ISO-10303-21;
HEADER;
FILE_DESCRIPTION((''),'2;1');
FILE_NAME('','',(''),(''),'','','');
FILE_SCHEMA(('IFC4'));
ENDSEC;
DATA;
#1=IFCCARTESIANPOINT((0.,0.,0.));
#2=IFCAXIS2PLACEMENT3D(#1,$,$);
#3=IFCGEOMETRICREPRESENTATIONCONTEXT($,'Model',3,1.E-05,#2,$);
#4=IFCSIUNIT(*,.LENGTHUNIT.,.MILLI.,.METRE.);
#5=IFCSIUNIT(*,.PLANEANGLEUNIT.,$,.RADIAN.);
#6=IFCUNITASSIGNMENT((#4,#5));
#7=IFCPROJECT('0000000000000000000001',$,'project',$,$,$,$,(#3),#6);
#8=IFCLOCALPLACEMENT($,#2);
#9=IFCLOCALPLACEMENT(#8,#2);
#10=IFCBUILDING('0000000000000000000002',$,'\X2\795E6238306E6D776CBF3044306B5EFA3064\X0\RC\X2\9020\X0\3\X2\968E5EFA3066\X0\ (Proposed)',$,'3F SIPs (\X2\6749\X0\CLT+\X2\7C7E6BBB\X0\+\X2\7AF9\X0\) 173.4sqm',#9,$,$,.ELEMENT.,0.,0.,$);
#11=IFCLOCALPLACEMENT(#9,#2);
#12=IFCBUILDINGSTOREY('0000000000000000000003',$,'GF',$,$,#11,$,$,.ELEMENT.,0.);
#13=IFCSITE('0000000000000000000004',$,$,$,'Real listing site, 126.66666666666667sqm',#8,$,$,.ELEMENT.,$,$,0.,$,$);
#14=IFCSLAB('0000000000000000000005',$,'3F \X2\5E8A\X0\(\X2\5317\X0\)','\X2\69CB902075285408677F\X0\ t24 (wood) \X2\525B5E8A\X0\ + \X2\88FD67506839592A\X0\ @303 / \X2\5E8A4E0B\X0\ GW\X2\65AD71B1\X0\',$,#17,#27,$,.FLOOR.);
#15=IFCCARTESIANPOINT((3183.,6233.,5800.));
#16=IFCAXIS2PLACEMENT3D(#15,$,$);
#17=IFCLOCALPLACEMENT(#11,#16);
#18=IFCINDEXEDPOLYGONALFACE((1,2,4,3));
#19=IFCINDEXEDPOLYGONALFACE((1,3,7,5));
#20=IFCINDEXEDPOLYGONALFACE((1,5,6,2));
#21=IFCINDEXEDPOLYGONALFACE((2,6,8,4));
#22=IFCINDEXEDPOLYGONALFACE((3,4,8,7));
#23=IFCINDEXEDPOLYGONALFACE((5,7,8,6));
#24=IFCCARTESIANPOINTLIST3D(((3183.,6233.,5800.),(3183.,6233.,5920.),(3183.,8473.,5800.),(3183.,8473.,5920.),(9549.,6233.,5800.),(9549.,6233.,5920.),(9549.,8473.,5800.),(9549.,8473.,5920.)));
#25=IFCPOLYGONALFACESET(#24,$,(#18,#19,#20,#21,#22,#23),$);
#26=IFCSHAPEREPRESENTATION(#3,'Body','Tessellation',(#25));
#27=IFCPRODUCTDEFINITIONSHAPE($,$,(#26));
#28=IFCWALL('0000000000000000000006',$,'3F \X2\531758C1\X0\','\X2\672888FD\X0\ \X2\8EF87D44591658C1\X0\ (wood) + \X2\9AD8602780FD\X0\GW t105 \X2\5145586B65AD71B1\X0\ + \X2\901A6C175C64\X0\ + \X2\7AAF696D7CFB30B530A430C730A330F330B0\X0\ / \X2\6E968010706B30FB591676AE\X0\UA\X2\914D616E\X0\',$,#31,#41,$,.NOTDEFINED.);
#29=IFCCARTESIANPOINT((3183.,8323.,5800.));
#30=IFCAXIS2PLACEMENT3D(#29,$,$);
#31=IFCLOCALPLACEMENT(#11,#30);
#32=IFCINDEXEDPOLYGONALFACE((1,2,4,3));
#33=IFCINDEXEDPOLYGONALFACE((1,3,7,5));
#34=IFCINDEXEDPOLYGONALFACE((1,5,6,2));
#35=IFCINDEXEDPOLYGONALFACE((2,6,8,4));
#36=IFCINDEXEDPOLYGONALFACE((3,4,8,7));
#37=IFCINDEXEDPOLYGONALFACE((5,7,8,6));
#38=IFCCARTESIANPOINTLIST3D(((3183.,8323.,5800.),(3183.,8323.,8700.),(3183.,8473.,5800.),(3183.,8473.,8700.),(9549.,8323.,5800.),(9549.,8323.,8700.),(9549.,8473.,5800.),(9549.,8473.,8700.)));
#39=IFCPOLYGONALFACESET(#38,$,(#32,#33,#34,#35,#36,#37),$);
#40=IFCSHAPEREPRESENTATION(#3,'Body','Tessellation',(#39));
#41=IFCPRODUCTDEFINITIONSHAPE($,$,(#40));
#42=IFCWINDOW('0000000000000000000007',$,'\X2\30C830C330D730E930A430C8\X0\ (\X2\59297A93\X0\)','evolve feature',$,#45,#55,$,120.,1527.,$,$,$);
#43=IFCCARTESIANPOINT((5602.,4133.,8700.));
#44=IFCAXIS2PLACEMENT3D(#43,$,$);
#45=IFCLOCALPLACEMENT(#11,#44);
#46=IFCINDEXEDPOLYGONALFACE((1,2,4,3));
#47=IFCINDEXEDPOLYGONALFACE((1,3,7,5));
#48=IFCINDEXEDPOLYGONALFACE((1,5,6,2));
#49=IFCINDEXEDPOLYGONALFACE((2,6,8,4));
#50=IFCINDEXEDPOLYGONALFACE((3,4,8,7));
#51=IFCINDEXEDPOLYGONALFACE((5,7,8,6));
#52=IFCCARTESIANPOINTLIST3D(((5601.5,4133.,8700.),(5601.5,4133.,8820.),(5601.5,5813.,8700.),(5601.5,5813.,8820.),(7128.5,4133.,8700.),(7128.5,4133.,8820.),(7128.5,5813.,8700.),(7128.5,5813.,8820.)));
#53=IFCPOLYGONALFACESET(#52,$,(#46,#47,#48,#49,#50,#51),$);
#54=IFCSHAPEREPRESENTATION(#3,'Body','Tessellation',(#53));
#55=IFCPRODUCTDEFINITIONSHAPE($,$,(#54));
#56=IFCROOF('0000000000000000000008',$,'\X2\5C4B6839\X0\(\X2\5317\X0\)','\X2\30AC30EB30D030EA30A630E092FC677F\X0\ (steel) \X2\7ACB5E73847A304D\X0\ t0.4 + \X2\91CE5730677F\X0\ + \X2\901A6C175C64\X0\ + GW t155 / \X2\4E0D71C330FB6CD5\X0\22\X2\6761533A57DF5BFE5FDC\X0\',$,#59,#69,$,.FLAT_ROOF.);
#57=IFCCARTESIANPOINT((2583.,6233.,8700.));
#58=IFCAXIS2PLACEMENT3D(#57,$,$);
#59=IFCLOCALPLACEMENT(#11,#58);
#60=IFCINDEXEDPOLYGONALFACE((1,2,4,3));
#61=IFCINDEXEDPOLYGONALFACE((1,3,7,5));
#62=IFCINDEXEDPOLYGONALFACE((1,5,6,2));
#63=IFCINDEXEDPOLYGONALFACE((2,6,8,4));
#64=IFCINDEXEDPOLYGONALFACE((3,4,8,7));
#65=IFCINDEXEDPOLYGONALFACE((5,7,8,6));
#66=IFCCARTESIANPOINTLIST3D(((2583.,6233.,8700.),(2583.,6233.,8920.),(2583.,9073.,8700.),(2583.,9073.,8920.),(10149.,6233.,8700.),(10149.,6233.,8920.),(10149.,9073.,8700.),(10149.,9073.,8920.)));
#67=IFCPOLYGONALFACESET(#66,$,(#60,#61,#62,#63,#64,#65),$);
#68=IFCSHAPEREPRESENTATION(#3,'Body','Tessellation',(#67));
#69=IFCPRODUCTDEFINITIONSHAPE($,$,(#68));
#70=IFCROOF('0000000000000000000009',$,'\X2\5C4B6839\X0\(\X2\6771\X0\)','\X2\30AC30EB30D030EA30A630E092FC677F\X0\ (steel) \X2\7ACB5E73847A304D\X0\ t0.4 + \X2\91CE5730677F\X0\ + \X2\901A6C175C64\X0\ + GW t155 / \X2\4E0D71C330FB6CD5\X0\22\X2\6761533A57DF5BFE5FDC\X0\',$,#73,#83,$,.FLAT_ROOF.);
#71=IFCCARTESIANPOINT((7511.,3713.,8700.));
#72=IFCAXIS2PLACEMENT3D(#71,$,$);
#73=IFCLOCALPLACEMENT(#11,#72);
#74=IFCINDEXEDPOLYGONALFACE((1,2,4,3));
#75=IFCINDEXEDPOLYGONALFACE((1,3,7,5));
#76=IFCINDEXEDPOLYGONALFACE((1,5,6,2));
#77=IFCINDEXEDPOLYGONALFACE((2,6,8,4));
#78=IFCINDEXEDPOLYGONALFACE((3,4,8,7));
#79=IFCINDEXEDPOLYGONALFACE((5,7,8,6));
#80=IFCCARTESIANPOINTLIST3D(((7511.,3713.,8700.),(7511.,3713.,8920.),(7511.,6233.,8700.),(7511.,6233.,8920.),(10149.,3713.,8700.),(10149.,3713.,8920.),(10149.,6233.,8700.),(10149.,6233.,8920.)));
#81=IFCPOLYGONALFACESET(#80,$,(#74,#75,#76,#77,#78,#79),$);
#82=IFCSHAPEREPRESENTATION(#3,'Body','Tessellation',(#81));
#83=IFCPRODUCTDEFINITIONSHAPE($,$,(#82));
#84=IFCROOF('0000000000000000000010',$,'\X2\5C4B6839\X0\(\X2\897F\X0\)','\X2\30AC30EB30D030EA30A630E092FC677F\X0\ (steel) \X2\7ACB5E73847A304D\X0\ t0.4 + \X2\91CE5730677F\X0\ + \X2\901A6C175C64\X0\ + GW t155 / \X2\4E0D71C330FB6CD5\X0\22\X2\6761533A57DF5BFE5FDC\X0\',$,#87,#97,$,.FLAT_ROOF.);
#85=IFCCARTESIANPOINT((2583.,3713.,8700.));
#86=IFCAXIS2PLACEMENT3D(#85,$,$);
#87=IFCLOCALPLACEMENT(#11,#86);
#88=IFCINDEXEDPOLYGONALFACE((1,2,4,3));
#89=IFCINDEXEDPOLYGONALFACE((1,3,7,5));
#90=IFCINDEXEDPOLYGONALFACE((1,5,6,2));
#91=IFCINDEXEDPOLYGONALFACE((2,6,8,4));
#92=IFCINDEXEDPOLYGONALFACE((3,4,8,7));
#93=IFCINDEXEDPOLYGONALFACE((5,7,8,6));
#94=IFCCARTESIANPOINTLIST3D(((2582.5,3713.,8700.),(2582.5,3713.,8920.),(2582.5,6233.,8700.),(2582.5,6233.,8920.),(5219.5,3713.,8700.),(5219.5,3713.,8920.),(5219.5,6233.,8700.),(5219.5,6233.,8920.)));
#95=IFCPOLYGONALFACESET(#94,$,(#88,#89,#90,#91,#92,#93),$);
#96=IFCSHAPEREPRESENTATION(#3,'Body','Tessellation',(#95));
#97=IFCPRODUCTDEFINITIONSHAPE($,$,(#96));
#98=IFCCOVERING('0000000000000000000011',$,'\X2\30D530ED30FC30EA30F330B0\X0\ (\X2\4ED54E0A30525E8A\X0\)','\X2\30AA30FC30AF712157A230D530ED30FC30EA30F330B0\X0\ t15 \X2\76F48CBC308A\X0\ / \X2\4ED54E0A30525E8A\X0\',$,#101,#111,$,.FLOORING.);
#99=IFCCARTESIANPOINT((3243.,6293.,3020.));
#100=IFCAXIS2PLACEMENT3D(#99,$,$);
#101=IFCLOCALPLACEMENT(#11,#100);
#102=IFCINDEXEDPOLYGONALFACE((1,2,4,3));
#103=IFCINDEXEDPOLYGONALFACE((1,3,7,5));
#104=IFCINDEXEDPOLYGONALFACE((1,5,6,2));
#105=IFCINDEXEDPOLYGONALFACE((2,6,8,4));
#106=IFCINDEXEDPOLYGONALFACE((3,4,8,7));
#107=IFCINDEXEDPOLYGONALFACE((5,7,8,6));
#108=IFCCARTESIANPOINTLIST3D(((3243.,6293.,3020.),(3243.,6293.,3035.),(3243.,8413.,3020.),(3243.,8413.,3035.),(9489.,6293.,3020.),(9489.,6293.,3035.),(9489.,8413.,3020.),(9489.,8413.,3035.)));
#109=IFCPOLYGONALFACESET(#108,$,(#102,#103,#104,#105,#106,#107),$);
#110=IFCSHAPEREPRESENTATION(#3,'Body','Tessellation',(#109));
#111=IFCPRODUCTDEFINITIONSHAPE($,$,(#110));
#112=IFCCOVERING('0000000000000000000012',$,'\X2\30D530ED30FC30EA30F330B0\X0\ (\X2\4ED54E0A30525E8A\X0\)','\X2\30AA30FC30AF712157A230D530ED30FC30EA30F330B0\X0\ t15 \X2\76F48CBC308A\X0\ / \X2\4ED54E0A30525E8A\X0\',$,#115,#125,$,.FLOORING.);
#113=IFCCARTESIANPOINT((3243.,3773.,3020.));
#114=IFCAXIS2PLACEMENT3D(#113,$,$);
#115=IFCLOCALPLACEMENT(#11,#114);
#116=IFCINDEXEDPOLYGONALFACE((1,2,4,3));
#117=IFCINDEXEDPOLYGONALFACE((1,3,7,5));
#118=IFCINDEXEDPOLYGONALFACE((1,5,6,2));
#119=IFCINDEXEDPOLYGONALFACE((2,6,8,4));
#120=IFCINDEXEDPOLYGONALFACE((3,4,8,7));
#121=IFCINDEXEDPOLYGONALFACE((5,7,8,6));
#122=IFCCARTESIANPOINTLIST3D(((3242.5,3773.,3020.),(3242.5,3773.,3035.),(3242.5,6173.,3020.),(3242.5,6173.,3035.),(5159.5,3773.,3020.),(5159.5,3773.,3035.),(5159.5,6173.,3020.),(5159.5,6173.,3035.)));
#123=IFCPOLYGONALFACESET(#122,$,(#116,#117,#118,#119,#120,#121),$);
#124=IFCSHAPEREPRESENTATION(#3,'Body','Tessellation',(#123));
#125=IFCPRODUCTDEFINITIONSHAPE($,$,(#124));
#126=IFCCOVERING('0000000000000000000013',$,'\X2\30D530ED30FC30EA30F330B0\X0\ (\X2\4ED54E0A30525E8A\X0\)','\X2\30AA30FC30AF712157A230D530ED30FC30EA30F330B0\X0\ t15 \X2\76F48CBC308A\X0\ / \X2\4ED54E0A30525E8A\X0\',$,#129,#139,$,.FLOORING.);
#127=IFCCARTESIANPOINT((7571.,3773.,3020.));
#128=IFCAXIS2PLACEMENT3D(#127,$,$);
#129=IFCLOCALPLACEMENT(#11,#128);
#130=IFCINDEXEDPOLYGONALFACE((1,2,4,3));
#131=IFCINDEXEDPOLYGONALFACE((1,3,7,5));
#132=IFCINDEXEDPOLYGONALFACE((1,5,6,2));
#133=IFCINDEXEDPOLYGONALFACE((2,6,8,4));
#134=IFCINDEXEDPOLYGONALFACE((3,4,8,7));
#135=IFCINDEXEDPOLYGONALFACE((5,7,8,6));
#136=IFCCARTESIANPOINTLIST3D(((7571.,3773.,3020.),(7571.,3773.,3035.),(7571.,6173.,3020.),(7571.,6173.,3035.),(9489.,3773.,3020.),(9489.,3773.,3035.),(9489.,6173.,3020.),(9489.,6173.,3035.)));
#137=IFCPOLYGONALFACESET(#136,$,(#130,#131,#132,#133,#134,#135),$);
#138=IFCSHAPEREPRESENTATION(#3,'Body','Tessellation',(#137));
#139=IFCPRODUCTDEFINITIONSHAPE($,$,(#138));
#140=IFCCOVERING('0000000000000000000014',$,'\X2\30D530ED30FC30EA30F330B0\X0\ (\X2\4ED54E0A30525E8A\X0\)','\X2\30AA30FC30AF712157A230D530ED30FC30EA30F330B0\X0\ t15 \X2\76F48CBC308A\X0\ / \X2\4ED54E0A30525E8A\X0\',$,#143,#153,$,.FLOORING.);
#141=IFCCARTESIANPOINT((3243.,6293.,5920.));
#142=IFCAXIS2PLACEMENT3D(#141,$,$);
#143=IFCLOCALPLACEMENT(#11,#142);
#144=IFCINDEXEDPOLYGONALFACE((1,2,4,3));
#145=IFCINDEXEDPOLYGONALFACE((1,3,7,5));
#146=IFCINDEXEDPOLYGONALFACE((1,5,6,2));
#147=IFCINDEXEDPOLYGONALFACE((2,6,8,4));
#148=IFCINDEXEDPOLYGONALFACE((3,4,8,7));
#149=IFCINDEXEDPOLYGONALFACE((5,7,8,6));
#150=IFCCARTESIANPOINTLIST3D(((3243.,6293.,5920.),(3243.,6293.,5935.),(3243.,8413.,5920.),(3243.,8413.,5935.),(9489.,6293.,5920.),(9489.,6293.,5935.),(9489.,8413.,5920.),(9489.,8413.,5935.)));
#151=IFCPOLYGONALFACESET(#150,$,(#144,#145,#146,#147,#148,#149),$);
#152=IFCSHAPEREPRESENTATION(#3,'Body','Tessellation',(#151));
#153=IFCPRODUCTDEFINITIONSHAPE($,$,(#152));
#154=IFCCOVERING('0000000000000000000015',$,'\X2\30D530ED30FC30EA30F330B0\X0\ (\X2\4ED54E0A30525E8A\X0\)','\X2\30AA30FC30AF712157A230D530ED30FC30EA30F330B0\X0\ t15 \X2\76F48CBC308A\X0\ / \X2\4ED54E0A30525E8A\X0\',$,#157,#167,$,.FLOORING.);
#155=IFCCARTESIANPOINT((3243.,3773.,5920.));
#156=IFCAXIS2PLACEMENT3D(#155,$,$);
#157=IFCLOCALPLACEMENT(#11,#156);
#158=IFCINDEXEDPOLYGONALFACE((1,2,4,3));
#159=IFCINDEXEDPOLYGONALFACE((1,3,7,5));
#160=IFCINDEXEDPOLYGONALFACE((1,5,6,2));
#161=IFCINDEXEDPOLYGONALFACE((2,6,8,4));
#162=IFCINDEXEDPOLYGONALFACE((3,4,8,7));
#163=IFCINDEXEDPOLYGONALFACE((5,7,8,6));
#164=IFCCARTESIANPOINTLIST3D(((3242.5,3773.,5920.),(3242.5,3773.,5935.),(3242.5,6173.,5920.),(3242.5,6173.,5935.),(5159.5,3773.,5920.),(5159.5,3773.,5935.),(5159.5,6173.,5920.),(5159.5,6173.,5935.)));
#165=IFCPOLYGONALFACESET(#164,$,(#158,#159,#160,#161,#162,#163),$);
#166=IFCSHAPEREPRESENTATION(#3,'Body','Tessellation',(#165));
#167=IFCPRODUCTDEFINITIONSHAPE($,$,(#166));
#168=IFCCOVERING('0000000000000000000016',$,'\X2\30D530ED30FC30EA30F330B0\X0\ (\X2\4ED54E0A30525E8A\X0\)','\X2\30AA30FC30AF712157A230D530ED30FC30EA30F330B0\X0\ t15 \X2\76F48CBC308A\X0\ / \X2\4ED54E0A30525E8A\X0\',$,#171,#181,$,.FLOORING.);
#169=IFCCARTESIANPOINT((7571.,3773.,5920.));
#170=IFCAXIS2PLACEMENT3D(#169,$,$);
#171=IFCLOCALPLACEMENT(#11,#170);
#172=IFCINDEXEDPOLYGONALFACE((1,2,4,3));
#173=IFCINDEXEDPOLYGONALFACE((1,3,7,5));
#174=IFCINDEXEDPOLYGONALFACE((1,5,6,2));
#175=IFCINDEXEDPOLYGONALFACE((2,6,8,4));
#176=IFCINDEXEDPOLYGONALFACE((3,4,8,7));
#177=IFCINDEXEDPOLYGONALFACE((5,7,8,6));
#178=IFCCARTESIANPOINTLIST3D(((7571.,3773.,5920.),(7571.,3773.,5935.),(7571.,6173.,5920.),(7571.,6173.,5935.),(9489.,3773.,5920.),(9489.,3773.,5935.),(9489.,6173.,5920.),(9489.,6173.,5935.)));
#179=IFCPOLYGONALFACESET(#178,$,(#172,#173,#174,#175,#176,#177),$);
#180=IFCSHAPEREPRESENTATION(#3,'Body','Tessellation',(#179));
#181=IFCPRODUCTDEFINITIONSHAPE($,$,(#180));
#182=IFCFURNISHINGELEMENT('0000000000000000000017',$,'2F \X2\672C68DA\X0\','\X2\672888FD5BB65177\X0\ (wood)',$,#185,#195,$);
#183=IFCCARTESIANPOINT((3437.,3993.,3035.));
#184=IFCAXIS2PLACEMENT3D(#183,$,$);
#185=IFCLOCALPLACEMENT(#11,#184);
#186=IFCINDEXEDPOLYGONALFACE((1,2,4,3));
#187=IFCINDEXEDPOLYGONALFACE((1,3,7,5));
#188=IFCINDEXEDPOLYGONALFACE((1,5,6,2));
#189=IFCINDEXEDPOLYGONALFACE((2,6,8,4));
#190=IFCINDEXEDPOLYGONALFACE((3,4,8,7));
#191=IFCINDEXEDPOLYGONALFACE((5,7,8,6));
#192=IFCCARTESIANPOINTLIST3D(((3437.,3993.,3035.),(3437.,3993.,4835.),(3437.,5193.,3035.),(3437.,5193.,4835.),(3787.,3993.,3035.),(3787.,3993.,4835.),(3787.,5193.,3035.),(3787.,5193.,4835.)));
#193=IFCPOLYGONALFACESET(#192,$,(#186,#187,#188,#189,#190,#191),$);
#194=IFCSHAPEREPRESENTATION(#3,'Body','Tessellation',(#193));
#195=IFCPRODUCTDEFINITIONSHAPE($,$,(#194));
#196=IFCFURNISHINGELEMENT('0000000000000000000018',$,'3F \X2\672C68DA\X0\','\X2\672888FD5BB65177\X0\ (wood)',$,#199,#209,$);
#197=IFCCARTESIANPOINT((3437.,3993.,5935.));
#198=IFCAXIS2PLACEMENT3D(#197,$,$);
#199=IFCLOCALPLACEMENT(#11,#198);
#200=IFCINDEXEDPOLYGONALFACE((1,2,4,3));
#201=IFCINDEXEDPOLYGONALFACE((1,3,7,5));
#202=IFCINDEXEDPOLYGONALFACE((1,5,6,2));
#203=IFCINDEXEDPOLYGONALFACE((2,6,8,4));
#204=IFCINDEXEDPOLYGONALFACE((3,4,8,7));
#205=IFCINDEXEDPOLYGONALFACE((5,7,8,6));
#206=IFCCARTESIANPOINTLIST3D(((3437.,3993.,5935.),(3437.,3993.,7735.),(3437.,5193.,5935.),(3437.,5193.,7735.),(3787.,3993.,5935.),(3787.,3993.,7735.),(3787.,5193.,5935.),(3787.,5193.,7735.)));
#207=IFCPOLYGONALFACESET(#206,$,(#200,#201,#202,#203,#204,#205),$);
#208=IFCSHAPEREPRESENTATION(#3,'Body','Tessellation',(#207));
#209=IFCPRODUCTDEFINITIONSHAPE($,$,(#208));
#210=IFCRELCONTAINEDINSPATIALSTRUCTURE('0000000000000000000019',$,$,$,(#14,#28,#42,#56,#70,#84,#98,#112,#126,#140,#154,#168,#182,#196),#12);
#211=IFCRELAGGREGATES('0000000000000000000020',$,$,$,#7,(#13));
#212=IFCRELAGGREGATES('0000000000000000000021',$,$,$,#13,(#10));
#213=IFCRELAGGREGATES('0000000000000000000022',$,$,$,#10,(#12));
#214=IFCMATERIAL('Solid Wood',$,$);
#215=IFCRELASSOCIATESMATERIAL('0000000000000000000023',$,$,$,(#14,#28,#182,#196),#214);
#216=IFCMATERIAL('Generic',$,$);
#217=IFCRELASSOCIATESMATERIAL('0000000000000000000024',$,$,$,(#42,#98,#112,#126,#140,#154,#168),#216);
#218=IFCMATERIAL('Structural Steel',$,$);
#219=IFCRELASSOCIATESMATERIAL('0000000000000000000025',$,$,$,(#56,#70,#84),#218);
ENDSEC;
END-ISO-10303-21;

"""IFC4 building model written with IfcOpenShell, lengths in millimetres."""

from ifc_helpers import new_model, si_unit, frame, frame_2d, origin, place, context, project, spatial, rectangle, extrude, material, element, save


model = new_model("IFC4")

# Units and contexts
model_context = context("Model", 3, precision=1e-05, world=origin())
ifc_project = project(units=[si_unit("LENGTHUNIT", "METRE", prefix="MILLI"), si_unit("PLANEANGLEUNIT", "RADIAN")], contexts=[model_context])

# Site, building, storey
site_placement = place(None, origin())
site = spatial("IfcSite", under=ifc_project, at=site_placement, ObjectType="Real listing site, 126.66666666666667sqm", CompositionType="ELEMENT", RefElevation=0.0)
building_placement = place(site_placement, origin())
building = spatial("IfcBuilding", under=site, at=building_placement, Name="神戸の海沿いに建つRC造3階建て (Proposed)", ObjectType="3F SIPs (杉CLT+籾殻+竹) 173.4sqm", CompositionType="ELEMENT", ElevationOfRefHeight=0.0, ElevationOfTerrain=0.0)
storey_placement = place(building_placement, origin())
storey = spatial("IfcBuildingStorey", under=building, at=storey_placement, Name="GF", CompositionType="ELEMENT", Elevation=0.0)

# Slab
ifc_material_1 = material(Name="Solid Wood")
slab_placement = place(storey_placement, frame((3183.0, 6233.0, 5800.0)))
element("IfcSlab", 1, at=slab_placement, inside=storey, material=ifc_material_1, Name="3F 床(北)", Description="構造用合板 t24 (wood) 剛床 + 製材根太 @303 / 床下 GW断熱", PredefinedType="FLOOR", context=model_context, shape_type="SweptSolid", body=[
    extrude(rectangle(XDim=6366.0, YDim=2240.0, at=frame_2d((3183.0, 1120.0))), frame((3183.0, 6233.0, 5800.0)), (0.0, 0.0, 1.0), 120.0),
])

# Wall
wall_1_placement = place(storey_placement, frame((3183.0, 8323.0, 5800.0)))
element("IfcWall", 2, at=wall_1_placement, inside=storey, material=ifc_material_1, Name="3F 北壁", Description="木製 軸組外壁 (wood) + 高性能GW t105 充填断熱 + 通気層 + 窯業系サイディング / 準耐火・外皮UA配慮", PredefinedType="NOTDEFINED", context=model_context, shape_type="SweptSolid", body=[
    extrude(rectangle(XDim=6366.0, YDim=150.0, at=frame_2d((3183.0, 75.0))), frame((3183.0, 8323.0, 5800.0)), (0.0, 0.0, 1.0), 2900.0),
])

# Window
ifc_material_2 = material(Name="Generic")
window_1_placement = place(storey_placement, frame((5602.0, 4133.0, 8700.0)))
element("IfcWindow", 3, at=window_1_placement, inside=storey, material=ifc_material_2, Name="トップライト (天窓)", Description="evolve feature", OverallHeight=120.0, OverallWidth=1527.0, context=model_context, shape_type="SweptSolid", body=[
    extrude(rectangle(XDim=1527.0, YDim=1680.0, at=frame_2d((763.0, 840.0))), frame((5602.0, 4133.0, 8700.0)), (0.0, 0.0, 1.0), 120.0),
])

# Roofs
ifc_material_3 = material(Name="Structural Steel")
roof_1_placement = place(storey_placement, frame((2583.0, 6233.0, 8700.0)))
element("IfcRoof", 4, at=roof_1_placement, inside=storey, material=ifc_material_3, Name="屋根(北)", Description="ガルバリウム鋼板 (steel) 立平葺き t0.4 + 野地板 + 通気層 + GW t155 / 不燃・法22条区域対応", PredefinedType="FLAT_ROOF", context=model_context, shape_type="SweptSolid", body=[
    extrude(rectangle(XDim=7566.0, YDim=2840.0, at=frame_2d((3783.0, 1420.0))), frame((2583.0, 6233.0, 8700.0)), (0.0, 0.0, 1.0), 220.0),
])
roof_2_placement = place(storey_placement, frame((7511.0, 3713.0, 8700.0)))
element("IfcRoof", 5, at=roof_2_placement, inside=storey, material=ifc_material_3, Name="屋根(東)", Description="ガルバリウム鋼板 (steel) 立平葺き t0.4 + 野地板 + 通気層 + GW t155 / 不燃・法22条区域対応", PredefinedType="FLAT_ROOF", context=model_context, shape_type="SweptSolid", body=[
    extrude(rectangle(XDim=2638.0, YDim=2520.0, at=frame_2d((1319.0, 1260.0))), frame((7511.0, 3713.0, 8700.0)), (0.0, 0.0, 1.0), 220.0),
])
roof_3_placement = place(storey_placement, frame((2583.0, 3713.0, 8700.0)))
element("IfcRoof", 6, at=roof_3_placement, inside=storey, material=ifc_material_3, Name="屋根(西)", Description="ガルバリウム鋼板 (steel) 立平葺き t0.4 + 野地板 + 通気層 + GW t155 / 不燃・法22条区域対応", PredefinedType="FLAT_ROOF", context=model_context, shape_type="SweptSolid", body=[
    extrude(rectangle(XDim=2637.0, YDim=2520.0, at=frame_2d((1318.0, 1260.0))), frame((2583.0, 3713.0, 8700.0)), (0.0, 0.0, 1.0), 220.0),
])

# Coverings
covering_1_placement = place(storey_placement, frame((3243.0, 6293.0, 3020.0)))
element("IfcCovering", 7, at=covering_1_placement, inside=storey, material=ifc_material_2, Name="フローリング (仕上げ床)", Description="オーク無垢フローリング t15 直貼り / 仕上げ床", PredefinedType="FLOORING", context=model_context, shape_type="SweptSolid", body=[
    extrude(rectangle(XDim=6246.0, YDim=2120.0, at=frame_2d((3123.0, 1060.0))), frame((3243.0, 6293.0, 3020.0)), (0.0, 0.0, 1.0), 15.0),
])
covering_2_placement = place(storey_placement, frame((3243.0, 3773.0, 3020.0)))
element("IfcCovering", 8, at=covering_2_placement, inside=storey, material=ifc_material_2, Name="フローリング (仕上げ床)", Description="オーク無垢フローリング t15 直貼り / 仕上げ床", PredefinedType="FLOORING", context=model_context, shape_type="SweptSolid", body=[
    extrude(rectangle(XDim=1917.0, YDim=2400.0, at=frame_2d((958.0, 1200.0))), frame((3243.0, 3773.0, 3020.0)), (0.0, 0.0, 1.0), 15.0),
])
covering_3_placement = place(storey_placement, frame((7571.0, 3773.0, 3020.0)))
element("IfcCovering", 9, at=covering_3_placement, inside=storey, material=ifc_material_2, Name="フローリング (仕上げ床)", Description="オーク無垢フローリング t15 直貼り / 仕上げ床", PredefinedType="FLOORING", context=model_context, shape_type="SweptSolid", body=[
    extrude(rectangle(XDim=1918.0, YDim=2400.0, at=frame_2d((959.0, 1200.0))), frame((7571.0, 3773.0, 3020.0)), (0.0, 0.0, 1.0), 15.0),
])
covering_4_placement = place(storey_placement, frame((3243.0, 6293.0, 5920.0)))
element("IfcCovering", 10, at=covering_4_placement, inside=storey, material=ifc_material_2, Name="フローリング (仕上げ床)", Description="オーク無垢フローリング t15 直貼り / 仕上げ床", PredefinedType="FLOORING", context=model_context, shape_type="SweptSolid", body=[
    extrude(rectangle(XDim=6246.0, YDim=2120.0, at=frame_2d((3123.0, 1060.0))), frame((3243.0, 6293.0, 5920.0)), (0.0, 0.0, 1.0), 15.0),
])
covering_5_placement = place(storey_placement, frame((3243.0, 3773.0, 5920.0)))
element("IfcCovering", 11, at=covering_5_placement, inside=storey, material=ifc_material_2, Name="フローリング (仕上げ床)", Description="オーク無垢フローリング t15 直貼り / 仕上げ床", PredefinedType="FLOORING", context=model_context, shape_type="SweptSolid", body=[
    extrude(rectangle(XDim=1917.0, YDim=2400.0, at=frame_2d((958.0, 1200.0))), frame((3243.0, 3773.0, 5920.0)), (0.0, 0.0, 1.0), 15.0),
])
covering_6_placement = place(storey_placement, frame((7571.0, 3773.0, 5920.0)))
element("IfcCovering", 12, at=covering_6_placement, inside=storey, material=ifc_material_2, Name="フローリング (仕上げ床)", Description="オーク無垢フローリング t15 直貼り / 仕上げ床", PredefinedType="FLOORING", context=model_context, shape_type="SweptSolid", body=[
    extrude(rectangle(XDim=1918.0, YDim=2400.0, at=frame_2d((959.0, 1200.0))), frame((7571.0, 3773.0, 5920.0)), (0.0, 0.0, 1.0), 15.0),
])

# Furnishing elements
furnishing_1_placement = place(storey_placement, frame((3437.0, 3993.0, 3035.0)))
element("IfcFurnishingElement", 13, at=furnishing_1_placement, inside=storey, material=ifc_material_1, Name="2F 本棚", Description="木製家具 (wood)", context=model_context, shape_type="SweptSolid", body=[
    extrude(rectangle(XDim=350.0, YDim=1200.0, at=frame_2d((175.0, 600.0))), frame((3437.0, 3993.0, 3035.0)), (0.0, 0.0, 1.0), 1800.0),
])
furnishing_2_placement = place(storey_placement, frame((3437.0, 3993.0, 5935.0)))
element("IfcFurnishingElement", 14, at=furnishing_2_placement, inside=storey, material=ifc_material_1, Name="3F 本棚", Description="木製家具 (wood)", context=model_context, shape_type="SweptSolid", body=[
    extrude(rectangle(XDim=350.0, YDim=1200.0, at=frame_2d((175.0, 600.0))), frame((3437.0, 3993.0, 5935.0)), (0.0, 0.0, 1.0), 1800.0),
])

save(model, "model.ifc")
